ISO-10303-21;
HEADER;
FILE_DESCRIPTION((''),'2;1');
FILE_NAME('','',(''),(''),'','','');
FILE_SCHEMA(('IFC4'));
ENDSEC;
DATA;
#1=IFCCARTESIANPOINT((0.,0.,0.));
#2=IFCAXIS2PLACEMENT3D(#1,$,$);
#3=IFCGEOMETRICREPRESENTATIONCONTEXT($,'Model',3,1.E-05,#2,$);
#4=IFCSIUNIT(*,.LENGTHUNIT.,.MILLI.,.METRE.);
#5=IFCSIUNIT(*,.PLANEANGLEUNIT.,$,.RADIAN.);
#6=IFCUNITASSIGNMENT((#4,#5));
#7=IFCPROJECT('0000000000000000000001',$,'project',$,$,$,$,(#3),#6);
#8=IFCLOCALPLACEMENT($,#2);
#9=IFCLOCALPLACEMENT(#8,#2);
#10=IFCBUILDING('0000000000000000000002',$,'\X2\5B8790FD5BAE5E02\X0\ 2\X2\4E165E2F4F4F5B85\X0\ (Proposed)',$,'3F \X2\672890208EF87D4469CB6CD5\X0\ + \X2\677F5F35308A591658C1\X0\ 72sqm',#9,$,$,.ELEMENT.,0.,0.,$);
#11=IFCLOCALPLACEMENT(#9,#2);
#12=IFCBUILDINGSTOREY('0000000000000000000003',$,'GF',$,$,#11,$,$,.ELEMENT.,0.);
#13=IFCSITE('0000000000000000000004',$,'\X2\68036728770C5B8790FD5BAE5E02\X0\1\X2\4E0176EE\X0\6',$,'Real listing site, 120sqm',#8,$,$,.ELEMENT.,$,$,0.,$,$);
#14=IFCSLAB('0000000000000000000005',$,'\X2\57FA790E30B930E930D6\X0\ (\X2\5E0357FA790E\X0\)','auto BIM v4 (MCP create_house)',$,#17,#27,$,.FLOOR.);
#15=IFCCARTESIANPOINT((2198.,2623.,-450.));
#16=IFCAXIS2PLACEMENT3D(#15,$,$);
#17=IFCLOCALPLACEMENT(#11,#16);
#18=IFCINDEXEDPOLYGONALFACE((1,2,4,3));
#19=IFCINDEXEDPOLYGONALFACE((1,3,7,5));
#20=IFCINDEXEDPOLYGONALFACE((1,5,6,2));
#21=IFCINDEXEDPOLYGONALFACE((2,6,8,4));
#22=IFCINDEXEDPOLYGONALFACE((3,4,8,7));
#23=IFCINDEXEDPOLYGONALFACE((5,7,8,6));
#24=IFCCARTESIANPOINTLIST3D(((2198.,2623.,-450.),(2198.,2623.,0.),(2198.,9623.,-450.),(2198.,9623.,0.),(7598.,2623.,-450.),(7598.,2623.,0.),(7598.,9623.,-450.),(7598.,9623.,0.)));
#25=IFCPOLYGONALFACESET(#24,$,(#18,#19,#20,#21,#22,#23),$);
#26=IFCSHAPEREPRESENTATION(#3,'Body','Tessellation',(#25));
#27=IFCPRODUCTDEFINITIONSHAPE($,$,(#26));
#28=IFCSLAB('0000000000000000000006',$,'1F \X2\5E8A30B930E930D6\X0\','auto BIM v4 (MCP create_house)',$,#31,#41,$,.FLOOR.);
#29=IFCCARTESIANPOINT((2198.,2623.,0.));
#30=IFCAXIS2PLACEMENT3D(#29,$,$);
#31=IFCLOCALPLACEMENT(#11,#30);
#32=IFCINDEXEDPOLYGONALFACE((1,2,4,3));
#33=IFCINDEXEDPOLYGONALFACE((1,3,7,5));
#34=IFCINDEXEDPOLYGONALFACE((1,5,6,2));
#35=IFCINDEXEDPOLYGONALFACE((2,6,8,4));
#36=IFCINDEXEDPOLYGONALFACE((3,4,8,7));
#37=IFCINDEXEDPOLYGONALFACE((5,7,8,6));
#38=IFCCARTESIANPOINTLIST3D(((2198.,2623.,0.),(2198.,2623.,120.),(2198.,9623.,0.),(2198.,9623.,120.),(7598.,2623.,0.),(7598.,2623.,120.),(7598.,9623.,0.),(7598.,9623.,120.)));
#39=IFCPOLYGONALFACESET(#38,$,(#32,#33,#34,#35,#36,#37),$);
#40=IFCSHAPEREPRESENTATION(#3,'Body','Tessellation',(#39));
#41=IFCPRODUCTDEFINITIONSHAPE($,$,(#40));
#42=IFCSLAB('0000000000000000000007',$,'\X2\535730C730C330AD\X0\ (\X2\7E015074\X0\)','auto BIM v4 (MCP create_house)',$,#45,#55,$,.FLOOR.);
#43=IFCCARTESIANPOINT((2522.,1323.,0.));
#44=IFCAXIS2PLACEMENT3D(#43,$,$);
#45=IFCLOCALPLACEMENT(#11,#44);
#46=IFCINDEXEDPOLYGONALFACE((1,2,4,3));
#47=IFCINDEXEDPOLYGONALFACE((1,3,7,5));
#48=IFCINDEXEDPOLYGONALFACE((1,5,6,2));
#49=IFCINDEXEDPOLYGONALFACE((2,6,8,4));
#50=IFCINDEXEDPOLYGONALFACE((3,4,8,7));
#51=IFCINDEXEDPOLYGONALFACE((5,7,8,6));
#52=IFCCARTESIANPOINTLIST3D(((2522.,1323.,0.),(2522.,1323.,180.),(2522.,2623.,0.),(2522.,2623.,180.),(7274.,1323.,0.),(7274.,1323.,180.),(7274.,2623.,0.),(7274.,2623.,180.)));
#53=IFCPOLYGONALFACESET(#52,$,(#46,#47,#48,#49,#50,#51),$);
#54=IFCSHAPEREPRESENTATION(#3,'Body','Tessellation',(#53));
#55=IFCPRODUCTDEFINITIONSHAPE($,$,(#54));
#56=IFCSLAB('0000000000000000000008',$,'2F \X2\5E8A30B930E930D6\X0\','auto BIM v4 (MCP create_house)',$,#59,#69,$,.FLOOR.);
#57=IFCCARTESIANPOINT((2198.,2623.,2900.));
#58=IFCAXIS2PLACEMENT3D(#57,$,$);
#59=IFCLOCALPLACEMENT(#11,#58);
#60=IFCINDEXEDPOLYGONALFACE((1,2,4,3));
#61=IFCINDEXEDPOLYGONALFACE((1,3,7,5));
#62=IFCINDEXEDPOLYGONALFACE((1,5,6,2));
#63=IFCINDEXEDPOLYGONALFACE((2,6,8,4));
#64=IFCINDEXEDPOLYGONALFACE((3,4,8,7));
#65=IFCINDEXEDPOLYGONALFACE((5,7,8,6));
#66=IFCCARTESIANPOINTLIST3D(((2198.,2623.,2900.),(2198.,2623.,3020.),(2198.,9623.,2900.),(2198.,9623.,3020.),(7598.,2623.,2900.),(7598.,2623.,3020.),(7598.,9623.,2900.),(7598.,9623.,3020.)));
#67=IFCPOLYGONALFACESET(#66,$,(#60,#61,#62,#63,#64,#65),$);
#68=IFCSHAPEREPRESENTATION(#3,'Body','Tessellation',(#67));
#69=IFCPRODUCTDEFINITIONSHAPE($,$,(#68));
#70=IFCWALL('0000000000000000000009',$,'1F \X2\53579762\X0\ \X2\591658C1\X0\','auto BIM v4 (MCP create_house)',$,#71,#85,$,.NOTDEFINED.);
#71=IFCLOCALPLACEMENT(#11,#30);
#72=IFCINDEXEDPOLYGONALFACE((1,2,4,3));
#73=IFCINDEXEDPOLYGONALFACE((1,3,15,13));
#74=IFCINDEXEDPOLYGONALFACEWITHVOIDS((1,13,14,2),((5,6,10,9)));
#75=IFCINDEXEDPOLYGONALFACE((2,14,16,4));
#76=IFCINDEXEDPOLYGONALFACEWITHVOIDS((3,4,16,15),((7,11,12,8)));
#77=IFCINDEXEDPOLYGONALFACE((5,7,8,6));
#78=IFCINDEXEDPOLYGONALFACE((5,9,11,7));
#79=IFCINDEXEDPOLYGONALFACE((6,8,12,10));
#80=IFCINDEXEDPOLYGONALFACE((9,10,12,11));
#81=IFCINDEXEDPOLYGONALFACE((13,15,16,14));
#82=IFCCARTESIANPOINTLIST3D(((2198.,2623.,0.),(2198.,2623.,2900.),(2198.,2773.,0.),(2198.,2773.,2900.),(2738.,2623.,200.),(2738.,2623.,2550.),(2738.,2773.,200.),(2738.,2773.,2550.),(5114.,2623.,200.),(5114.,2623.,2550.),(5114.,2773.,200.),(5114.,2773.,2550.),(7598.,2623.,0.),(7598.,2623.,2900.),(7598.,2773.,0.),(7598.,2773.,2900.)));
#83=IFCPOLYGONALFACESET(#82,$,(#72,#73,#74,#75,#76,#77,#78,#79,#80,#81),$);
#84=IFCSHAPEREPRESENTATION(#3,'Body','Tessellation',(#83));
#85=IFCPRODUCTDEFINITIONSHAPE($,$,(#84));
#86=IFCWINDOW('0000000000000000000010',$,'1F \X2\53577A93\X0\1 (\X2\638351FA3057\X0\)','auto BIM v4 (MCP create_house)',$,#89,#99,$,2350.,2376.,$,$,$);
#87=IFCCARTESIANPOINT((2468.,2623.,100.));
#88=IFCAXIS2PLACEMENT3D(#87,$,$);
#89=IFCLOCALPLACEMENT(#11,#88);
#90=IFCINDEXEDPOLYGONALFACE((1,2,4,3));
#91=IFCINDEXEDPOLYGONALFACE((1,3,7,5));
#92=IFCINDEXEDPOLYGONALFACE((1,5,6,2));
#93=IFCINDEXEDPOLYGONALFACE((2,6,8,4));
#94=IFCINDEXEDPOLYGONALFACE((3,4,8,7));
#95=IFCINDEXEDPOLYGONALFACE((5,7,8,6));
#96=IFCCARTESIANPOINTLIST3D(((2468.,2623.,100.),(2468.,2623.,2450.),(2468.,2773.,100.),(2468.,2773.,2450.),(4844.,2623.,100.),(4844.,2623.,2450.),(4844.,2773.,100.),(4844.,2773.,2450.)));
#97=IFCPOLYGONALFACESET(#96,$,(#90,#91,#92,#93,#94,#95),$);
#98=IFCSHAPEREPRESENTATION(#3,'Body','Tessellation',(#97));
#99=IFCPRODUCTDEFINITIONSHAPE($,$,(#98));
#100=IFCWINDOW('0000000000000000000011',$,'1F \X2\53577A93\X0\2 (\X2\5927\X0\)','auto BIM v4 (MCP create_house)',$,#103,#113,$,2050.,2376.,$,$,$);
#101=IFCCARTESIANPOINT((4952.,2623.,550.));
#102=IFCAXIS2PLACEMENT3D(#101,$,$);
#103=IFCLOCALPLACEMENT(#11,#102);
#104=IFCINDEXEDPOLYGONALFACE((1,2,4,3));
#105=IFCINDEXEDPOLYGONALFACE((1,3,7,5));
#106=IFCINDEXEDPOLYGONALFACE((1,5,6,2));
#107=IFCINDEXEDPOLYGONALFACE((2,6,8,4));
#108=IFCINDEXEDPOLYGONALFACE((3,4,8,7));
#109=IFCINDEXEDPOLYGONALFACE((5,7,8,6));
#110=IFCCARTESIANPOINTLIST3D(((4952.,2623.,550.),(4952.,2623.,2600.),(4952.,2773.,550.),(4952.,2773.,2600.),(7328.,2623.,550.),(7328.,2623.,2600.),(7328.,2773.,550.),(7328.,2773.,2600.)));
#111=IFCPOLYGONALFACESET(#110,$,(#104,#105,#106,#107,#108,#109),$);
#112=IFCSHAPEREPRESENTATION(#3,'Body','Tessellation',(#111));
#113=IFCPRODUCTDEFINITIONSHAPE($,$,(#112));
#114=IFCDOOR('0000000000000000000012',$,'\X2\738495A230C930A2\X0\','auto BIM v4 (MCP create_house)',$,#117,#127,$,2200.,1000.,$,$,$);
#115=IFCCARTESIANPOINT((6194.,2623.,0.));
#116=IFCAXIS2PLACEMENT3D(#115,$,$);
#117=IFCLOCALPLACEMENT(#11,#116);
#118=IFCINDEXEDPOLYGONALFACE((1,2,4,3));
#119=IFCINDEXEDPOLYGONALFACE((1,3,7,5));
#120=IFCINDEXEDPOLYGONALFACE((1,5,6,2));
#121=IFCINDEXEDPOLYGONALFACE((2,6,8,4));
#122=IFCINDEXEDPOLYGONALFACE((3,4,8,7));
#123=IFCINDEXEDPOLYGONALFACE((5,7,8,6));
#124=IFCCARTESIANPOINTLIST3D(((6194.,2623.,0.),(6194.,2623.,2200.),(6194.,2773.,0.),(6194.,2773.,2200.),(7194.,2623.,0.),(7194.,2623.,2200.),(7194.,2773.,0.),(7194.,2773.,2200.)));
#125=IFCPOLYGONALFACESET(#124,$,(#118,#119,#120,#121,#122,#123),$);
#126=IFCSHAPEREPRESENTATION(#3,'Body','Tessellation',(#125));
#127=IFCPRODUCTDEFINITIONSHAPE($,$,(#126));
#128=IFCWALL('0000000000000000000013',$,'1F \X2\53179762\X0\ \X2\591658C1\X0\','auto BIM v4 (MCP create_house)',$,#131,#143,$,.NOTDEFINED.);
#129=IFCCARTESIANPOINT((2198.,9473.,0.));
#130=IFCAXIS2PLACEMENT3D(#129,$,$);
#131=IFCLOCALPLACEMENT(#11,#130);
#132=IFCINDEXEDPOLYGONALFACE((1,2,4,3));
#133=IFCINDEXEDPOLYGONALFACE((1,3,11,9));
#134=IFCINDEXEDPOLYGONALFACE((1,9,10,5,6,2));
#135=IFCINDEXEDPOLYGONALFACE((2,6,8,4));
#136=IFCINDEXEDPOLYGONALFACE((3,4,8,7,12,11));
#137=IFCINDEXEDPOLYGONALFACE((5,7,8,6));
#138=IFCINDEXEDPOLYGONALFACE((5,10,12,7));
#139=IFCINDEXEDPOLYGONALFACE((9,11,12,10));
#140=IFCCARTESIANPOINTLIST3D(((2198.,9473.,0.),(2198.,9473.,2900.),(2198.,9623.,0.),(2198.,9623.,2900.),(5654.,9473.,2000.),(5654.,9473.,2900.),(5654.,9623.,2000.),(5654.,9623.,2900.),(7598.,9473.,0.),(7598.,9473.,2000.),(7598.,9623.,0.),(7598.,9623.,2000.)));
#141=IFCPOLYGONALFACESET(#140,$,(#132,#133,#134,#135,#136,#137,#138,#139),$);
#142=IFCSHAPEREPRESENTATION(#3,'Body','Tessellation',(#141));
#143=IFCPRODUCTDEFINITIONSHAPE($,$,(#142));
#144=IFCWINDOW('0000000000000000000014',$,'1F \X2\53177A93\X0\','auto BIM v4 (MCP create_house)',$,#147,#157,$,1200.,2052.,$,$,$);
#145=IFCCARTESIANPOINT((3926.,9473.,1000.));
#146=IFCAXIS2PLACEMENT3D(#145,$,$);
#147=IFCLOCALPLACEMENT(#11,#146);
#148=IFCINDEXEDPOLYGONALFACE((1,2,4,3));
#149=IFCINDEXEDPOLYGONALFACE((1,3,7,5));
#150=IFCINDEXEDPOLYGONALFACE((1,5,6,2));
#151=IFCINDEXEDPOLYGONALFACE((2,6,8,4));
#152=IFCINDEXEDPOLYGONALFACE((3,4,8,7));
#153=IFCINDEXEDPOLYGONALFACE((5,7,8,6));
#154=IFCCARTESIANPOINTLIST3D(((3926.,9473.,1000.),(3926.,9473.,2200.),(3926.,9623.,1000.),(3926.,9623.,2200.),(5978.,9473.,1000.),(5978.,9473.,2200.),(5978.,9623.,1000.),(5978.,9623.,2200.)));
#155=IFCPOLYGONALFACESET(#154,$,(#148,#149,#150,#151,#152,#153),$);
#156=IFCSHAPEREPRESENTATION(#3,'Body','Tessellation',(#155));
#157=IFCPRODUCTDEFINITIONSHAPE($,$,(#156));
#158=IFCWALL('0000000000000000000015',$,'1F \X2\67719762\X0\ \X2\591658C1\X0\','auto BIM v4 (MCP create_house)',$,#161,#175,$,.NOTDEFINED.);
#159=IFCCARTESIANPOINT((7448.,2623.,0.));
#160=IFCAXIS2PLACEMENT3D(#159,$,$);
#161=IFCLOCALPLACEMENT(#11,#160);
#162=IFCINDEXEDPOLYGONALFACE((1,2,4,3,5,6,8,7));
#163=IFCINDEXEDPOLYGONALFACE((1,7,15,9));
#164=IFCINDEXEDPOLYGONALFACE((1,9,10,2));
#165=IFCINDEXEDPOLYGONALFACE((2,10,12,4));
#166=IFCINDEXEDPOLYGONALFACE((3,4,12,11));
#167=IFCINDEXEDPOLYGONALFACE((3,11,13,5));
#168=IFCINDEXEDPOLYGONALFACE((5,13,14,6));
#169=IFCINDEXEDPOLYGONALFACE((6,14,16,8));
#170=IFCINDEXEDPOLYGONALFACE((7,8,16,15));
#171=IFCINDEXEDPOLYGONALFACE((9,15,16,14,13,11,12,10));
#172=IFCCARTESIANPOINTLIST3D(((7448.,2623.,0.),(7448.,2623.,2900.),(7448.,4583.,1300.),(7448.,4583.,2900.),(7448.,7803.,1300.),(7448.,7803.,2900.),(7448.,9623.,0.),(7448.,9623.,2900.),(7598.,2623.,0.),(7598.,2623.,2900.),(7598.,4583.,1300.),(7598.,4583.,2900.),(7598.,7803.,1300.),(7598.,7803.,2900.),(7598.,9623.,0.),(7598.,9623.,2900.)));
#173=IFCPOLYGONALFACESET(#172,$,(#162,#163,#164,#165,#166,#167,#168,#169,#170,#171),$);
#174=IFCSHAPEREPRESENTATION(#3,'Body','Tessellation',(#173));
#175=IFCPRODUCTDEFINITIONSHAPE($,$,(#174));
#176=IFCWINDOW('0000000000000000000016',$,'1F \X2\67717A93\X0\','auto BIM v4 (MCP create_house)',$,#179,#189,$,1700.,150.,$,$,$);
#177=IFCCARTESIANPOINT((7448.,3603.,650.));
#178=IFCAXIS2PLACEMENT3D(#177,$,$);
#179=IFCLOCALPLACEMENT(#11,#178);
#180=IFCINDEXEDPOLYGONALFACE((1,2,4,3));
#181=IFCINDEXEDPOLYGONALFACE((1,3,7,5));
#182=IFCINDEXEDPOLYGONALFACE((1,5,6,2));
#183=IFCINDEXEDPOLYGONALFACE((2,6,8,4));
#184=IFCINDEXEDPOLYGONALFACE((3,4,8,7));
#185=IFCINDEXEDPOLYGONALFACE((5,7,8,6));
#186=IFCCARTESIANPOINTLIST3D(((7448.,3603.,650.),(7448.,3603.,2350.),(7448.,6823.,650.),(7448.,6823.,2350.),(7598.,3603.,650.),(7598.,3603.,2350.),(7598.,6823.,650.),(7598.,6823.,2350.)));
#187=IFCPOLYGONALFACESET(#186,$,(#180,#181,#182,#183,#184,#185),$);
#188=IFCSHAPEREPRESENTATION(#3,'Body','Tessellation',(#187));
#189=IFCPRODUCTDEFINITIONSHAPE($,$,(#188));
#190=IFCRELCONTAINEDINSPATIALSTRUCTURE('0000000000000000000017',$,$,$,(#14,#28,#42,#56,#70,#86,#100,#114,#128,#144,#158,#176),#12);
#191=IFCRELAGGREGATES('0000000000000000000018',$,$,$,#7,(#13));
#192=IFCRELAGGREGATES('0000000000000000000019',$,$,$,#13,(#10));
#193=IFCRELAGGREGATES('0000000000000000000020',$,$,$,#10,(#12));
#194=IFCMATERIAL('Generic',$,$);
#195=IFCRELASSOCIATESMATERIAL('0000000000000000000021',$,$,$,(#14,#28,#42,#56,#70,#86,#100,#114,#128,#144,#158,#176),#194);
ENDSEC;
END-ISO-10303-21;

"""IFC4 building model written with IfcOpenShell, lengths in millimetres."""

from ifc_helpers import new_model, si_unit, frame, frame_2d, origin, place, context, project, spatial, rectangle, extrude, material, element, fill, save


model = new_model("IFC4")

# Units and contexts
model_context = context("Model", 3, precision=1e-05, world=origin())
ifc_project = project(units=[si_unit("LENGTHUNIT", "METRE", prefix="MILLI"), si_unit("PLANEANGLEUNIT", "RADIAN")], contexts=[model_context])

# Site, building, storey
site_placement = place(None, origin())
site = spatial("IfcSite", under=ifc_project, at=site_placement, Name="栃木県宇都宮市1丁目6", ObjectType="Real listing site, 120sqm", CompositionType="ELEMENT", RefElevation=0.0)
building_placement = place(site_placement, origin())
building = spatial("IfcBuilding", under=site, at=building_placement, Name="宇都宮市 2世帯住宅 (Proposed)", ObjectType="3F 木造軸組構法 + 板張り外壁 72sqm", CompositionType="ELEMENT", ElevationOfRefHeight=0.0, ElevationOfTerrain=0.0)
storey_placement = place(building_placement, origin())
storey = spatial("IfcBuildingStorey", under=building, at=storey_placement, Name="GF", CompositionType="ELEMENT", Elevation=0.0)

# Slabs
ifc_material = material(Name="Generic")
slab_1_placement = place(storey_placement, frame((2198.0, 2623.0, -450.0)))
element("IfcSlab", 1, at=slab_1_placement, inside=storey, material=ifc_material, Name="基礎スラブ (布基礎)", Description="auto BIM v4 (MCP create_house)", PredefinedType="FLOOR", context=model_context, shape_type="SweptSolid", body=[
    extrude(rectangle(XDim=5400.0, YDim=7000.0, at=frame_2d((2700.0, 3500.0))), frame((2198.0, 2623.0, -450.0)), (0.0, 0.0, 1.0), 450.0),
])
slab_2_placement = place(storey_placement, frame((2198.0, 2623.0, 0.0)))
element("IfcSlab", 2, at=slab_2_placement, inside=storey, material=ifc_material, Name="1F 床スラブ", Description="auto BIM v4 (MCP create_house)", PredefinedType="FLOOR", context=model_context, shape_type="SweptSolid", body=[
    extrude(rectangle(XDim=5400.0, YDim=7000.0, at=frame_2d((2700.0, 3500.0))), frame((2198.0, 2623.0, 0.0)), (0.0, 0.0, 1.0), 120.0),
])
slab_3_placement = place(storey_placement, frame((2522.0, 1323.0, 0.0)))
element("IfcSlab", 3, at=slab_3_placement, inside=storey, material=ifc_material, Name="南デッキ (縁側)", Description="auto BIM v4 (MCP create_house)", PredefinedType="FLOOR", context=model_context, shape_type="SweptSolid", body=[
    extrude(rectangle(XDim=4752.0, YDim=1300.0, at=frame_2d((2376.0, 650.0))), frame((2522.0, 1323.0, 0.0)), (0.0, 0.0, 1.0), 180.0),
])
slab_4_placement = place(storey_placement, frame((2198.0, 2623.0, 2900.0)))
element("IfcSlab", 4, at=slab_4_placement, inside=storey, material=ifc_material, Name="2F 床スラブ", Description="auto BIM v4 (MCP create_house)", PredefinedType="FLOOR", context=model_context, shape_type="SweptSolid", body=[
    extrude(rectangle(XDim=5400.0, YDim=7000.0, at=frame_2d((2700.0, 3500.0))), frame((2198.0, 2623.0, 2900.0)), (0.0, 0.0, 1.0), 120.0),
])

# Wall, openings, windows, door
wall_1_placement = place(storey_placement, frame((2198.0, 2623.0, 0.0)))
wall_1 = element("IfcWall", 5, at=wall_1_placement, inside=storey, material=ifc_material, Name="1F 南面 外壁", Description="auto BIM v4 (MCP create_house)", PredefinedType="NOTDEFINED", context=model_context, shape_type="SweptSolid", body=[
    extrude(rectangle(XDim=5400.0, YDim=150.0, at=frame_2d((2700.0, 75.0))), frame((2198.0, 2623.0, 0.0)), (0.0, 0.0, 1.0), 2900.0),
])
opening_1_placement = place(storey_placement, frame((2468.0, 2623.0, 100.0)))
opening_1 = element("IfcOpeningElement", 6, at=opening_1_placement, cuts=wall_1, PredefinedType="NOTDEFINED", context=model_context, shape_type="SweptSolid", body=[
    extrude(rectangle(XDim=2376.0, YDim=150.0, at=frame_2d((1188.0, 75.0))), frame((2468.0, 2623.0, 100.0)), (0.0, 0.0, 1.0), 2350.0),
])
opening_2_placement = place(storey_placement, frame((4952.0, 2623.0, 550.0)))
opening_2 = element("IfcOpeningElement", 7, at=opening_2_placement, cuts=wall_1, PredefinedType="NOTDEFINED", context=model_context, shape_type="SweptSolid", body=[
    extrude(rectangle(XDim=2376.0, YDim=150.0, at=frame_2d((1188.0, 75.0))), frame((4952.0, 2623.0, 550.0)), (0.0, 0.0, 1.0), 2050.0),
])
opening_3_placement = place(storey_placement, frame((6194.0, 2623.0, 0.0)))
opening_3 = element("IfcOpeningElement", 8, at=opening_3_placement, cuts=wall_1, PredefinedType="NOTDEFINED", context=model_context, shape_type="SweptSolid", body=[
    extrude(rectangle(XDim=1000.0, YDim=150.0, at=frame_2d((500.0, 75.0))), frame((6194.0, 2623.0, 0.0)), (0.0, 0.0, 1.0), 2200.0),
])
window_1_placement = place(storey_placement, frame((2468.0, 2623.0, 100.0)))
window_1 = element("IfcWindow", 9, at=window_1_placement, inside=storey, material=ifc_material, Name="1F 南窓1 (掃出し)", Description="auto BIM v4 (MCP create_house)", OverallHeight=2350.0, OverallWidth=2376.0, context=model_context, shape_type="SweptSolid", body=[
    extrude(rectangle(XDim=2376.0, YDim=150.0, at=frame_2d((1188.0, 75.0))), frame((2468.0, 2623.0, 100.0)), (0.0, 0.0, 1.0), 2350.0),
])
fill(opening_1, window_1)
window_2_placement = place(storey_placement, frame((4952.0, 2623.0, 550.0)))
window_2 = element("IfcWindow", 10, at=window_2_placement, inside=storey, material=ifc_material, Name="1F 南窓2 (大)", Description="auto BIM v4 (MCP create_house)", OverallHeight=2050.0, OverallWidth=2376.0, context=model_context, shape_type="SweptSolid", body=[
    extrude(rectangle(XDim=2376.0, YDim=150.0, at=frame_2d((1188.0, 75.0))), frame((4952.0, 2623.0, 550.0)), (0.0, 0.0, 1.0), 2050.0),
])
fill(opening_2, window_2)
door_placement = place(storey_placement, frame((6194.0, 2623.0, 0.0)))
door = element("IfcDoor", 11, at=door_placement, inside=storey, material=ifc_material, Name="玄関ドア", Description="auto BIM v4 (MCP create_house)", OverallHeight=2200.0, OverallWidth=1000.0, context=model_context, shape_type="SweptSolid", body=[
    extrude(rectangle(XDim=1000.0, YDim=150.0, at=frame_2d((500.0, 75.0))), frame((6194.0, 2623.0, 0.0)), (0.0, 0.0, 1.0), 2200.0),
])
fill(opening_3, door)

# Walls, openings, windows
wall_2_placement = place(storey_placement, frame((2198.0, 9473.0, 0.0)))
wall_2 = element("IfcWall", 12, at=wall_2_placement, inside=storey, material=ifc_material, Name="1F 北面 外壁", Description="auto BIM v4 (MCP create_house)", PredefinedType="NOTDEFINED", context=model_context, shape_type="SweptSolid", body=[
    extrude(rectangle(XDim=5400.0, YDim=150.0, at=frame_2d((2700.0, 75.0))), frame((2198.0, 9473.0, 0.0)), (0.0, 0.0, 1.0), 2900.0),
])
opening_4_placement = place(storey_placement, frame((3926.0, 9473.0, 1000.0)))
opening_4 = element("IfcOpeningElement", 13, at=opening_4_placement, cuts=wall_2, PredefinedType="NOTDEFINED", context=model_context, shape_type="SweptSolid", body=[
    extrude(rectangle(XDim=2052.0, YDim=150.0, at=frame_2d((1026.0, 75.0))), frame((3926.0, 9473.0, 1000.0)), (0.0, 0.0, 1.0), 1200.0),
])
window_3_placement = place(storey_placement, frame((3926.0, 9473.0, 1000.0)))
window_3 = element("IfcWindow", 14, at=window_3_placement, inside=storey, material=ifc_material, Name="1F 北窓", Description="auto BIM v4 (MCP create_house)", OverallHeight=1200.0, OverallWidth=2052.0, context=model_context, shape_type="SweptSolid", body=[
    extrude(rectangle(XDim=2052.0, YDim=150.0, at=frame_2d((1026.0, 75.0))), frame((3926.0, 9473.0, 1000.0)), (0.0, 0.0, 1.0), 1200.0),
])
fill(opening_4, window_3)
wall_3_placement = place(storey_placement, frame((7448.0, 2623.0, 0.0)))
wall_3 = element("IfcWall", 15, at=wall_3_placement, inside=storey, material=ifc_material, Name="1F 東面 外壁", Description="auto BIM v4 (MCP create_house)", PredefinedType="NOTDEFINED", context=model_context, shape_type="SweptSolid", body=[
    extrude(rectangle(XDim=150.0, YDim=7000.0, at=frame_2d((75.0, 3500.0))), frame((7448.0, 2623.0, 0.0)), (0.0, 0.0, 1.0), 2900.0),
])
opening_5_placement = place(storey_placement, frame((7448.0, 3603.0, 650.0)))
opening_5 = element("IfcOpeningElement", 16, at=opening_5_placement, cuts=wall_3, PredefinedType="NOTDEFINED", context=model_context, shape_type="SweptSolid", body=[
    extrude(rectangle(XDim=150.0, YDim=3220.0, at=frame_2d((75.0, 1610.0))), frame((7448.0, 3603.0, 650.0)), (0.0, 0.0, 1.0), 1700.0),
])
window_4_placement = place(storey_placement, frame((7448.0, 3603.0, 650.0)))
window_4 = element("IfcWindow", 17, at=window_4_placement, inside=storey, material=ifc_material, Name="1F 東窓", Description="auto BIM v4 (MCP create_house)", OverallHeight=1700.0, OverallWidth=150.0, context=model_context, shape_type="SweptSolid", body=[
    extrude(rectangle(XDim=150.0, YDim=3220.0, at=frame_2d((75.0, 1610.0))), frame((7448.0, 3603.0, 650.0)), (0.0, 0.0, 1.0), 1700.0),
])
fill(opening_5, window_4)

save(model, "model.ifc")
